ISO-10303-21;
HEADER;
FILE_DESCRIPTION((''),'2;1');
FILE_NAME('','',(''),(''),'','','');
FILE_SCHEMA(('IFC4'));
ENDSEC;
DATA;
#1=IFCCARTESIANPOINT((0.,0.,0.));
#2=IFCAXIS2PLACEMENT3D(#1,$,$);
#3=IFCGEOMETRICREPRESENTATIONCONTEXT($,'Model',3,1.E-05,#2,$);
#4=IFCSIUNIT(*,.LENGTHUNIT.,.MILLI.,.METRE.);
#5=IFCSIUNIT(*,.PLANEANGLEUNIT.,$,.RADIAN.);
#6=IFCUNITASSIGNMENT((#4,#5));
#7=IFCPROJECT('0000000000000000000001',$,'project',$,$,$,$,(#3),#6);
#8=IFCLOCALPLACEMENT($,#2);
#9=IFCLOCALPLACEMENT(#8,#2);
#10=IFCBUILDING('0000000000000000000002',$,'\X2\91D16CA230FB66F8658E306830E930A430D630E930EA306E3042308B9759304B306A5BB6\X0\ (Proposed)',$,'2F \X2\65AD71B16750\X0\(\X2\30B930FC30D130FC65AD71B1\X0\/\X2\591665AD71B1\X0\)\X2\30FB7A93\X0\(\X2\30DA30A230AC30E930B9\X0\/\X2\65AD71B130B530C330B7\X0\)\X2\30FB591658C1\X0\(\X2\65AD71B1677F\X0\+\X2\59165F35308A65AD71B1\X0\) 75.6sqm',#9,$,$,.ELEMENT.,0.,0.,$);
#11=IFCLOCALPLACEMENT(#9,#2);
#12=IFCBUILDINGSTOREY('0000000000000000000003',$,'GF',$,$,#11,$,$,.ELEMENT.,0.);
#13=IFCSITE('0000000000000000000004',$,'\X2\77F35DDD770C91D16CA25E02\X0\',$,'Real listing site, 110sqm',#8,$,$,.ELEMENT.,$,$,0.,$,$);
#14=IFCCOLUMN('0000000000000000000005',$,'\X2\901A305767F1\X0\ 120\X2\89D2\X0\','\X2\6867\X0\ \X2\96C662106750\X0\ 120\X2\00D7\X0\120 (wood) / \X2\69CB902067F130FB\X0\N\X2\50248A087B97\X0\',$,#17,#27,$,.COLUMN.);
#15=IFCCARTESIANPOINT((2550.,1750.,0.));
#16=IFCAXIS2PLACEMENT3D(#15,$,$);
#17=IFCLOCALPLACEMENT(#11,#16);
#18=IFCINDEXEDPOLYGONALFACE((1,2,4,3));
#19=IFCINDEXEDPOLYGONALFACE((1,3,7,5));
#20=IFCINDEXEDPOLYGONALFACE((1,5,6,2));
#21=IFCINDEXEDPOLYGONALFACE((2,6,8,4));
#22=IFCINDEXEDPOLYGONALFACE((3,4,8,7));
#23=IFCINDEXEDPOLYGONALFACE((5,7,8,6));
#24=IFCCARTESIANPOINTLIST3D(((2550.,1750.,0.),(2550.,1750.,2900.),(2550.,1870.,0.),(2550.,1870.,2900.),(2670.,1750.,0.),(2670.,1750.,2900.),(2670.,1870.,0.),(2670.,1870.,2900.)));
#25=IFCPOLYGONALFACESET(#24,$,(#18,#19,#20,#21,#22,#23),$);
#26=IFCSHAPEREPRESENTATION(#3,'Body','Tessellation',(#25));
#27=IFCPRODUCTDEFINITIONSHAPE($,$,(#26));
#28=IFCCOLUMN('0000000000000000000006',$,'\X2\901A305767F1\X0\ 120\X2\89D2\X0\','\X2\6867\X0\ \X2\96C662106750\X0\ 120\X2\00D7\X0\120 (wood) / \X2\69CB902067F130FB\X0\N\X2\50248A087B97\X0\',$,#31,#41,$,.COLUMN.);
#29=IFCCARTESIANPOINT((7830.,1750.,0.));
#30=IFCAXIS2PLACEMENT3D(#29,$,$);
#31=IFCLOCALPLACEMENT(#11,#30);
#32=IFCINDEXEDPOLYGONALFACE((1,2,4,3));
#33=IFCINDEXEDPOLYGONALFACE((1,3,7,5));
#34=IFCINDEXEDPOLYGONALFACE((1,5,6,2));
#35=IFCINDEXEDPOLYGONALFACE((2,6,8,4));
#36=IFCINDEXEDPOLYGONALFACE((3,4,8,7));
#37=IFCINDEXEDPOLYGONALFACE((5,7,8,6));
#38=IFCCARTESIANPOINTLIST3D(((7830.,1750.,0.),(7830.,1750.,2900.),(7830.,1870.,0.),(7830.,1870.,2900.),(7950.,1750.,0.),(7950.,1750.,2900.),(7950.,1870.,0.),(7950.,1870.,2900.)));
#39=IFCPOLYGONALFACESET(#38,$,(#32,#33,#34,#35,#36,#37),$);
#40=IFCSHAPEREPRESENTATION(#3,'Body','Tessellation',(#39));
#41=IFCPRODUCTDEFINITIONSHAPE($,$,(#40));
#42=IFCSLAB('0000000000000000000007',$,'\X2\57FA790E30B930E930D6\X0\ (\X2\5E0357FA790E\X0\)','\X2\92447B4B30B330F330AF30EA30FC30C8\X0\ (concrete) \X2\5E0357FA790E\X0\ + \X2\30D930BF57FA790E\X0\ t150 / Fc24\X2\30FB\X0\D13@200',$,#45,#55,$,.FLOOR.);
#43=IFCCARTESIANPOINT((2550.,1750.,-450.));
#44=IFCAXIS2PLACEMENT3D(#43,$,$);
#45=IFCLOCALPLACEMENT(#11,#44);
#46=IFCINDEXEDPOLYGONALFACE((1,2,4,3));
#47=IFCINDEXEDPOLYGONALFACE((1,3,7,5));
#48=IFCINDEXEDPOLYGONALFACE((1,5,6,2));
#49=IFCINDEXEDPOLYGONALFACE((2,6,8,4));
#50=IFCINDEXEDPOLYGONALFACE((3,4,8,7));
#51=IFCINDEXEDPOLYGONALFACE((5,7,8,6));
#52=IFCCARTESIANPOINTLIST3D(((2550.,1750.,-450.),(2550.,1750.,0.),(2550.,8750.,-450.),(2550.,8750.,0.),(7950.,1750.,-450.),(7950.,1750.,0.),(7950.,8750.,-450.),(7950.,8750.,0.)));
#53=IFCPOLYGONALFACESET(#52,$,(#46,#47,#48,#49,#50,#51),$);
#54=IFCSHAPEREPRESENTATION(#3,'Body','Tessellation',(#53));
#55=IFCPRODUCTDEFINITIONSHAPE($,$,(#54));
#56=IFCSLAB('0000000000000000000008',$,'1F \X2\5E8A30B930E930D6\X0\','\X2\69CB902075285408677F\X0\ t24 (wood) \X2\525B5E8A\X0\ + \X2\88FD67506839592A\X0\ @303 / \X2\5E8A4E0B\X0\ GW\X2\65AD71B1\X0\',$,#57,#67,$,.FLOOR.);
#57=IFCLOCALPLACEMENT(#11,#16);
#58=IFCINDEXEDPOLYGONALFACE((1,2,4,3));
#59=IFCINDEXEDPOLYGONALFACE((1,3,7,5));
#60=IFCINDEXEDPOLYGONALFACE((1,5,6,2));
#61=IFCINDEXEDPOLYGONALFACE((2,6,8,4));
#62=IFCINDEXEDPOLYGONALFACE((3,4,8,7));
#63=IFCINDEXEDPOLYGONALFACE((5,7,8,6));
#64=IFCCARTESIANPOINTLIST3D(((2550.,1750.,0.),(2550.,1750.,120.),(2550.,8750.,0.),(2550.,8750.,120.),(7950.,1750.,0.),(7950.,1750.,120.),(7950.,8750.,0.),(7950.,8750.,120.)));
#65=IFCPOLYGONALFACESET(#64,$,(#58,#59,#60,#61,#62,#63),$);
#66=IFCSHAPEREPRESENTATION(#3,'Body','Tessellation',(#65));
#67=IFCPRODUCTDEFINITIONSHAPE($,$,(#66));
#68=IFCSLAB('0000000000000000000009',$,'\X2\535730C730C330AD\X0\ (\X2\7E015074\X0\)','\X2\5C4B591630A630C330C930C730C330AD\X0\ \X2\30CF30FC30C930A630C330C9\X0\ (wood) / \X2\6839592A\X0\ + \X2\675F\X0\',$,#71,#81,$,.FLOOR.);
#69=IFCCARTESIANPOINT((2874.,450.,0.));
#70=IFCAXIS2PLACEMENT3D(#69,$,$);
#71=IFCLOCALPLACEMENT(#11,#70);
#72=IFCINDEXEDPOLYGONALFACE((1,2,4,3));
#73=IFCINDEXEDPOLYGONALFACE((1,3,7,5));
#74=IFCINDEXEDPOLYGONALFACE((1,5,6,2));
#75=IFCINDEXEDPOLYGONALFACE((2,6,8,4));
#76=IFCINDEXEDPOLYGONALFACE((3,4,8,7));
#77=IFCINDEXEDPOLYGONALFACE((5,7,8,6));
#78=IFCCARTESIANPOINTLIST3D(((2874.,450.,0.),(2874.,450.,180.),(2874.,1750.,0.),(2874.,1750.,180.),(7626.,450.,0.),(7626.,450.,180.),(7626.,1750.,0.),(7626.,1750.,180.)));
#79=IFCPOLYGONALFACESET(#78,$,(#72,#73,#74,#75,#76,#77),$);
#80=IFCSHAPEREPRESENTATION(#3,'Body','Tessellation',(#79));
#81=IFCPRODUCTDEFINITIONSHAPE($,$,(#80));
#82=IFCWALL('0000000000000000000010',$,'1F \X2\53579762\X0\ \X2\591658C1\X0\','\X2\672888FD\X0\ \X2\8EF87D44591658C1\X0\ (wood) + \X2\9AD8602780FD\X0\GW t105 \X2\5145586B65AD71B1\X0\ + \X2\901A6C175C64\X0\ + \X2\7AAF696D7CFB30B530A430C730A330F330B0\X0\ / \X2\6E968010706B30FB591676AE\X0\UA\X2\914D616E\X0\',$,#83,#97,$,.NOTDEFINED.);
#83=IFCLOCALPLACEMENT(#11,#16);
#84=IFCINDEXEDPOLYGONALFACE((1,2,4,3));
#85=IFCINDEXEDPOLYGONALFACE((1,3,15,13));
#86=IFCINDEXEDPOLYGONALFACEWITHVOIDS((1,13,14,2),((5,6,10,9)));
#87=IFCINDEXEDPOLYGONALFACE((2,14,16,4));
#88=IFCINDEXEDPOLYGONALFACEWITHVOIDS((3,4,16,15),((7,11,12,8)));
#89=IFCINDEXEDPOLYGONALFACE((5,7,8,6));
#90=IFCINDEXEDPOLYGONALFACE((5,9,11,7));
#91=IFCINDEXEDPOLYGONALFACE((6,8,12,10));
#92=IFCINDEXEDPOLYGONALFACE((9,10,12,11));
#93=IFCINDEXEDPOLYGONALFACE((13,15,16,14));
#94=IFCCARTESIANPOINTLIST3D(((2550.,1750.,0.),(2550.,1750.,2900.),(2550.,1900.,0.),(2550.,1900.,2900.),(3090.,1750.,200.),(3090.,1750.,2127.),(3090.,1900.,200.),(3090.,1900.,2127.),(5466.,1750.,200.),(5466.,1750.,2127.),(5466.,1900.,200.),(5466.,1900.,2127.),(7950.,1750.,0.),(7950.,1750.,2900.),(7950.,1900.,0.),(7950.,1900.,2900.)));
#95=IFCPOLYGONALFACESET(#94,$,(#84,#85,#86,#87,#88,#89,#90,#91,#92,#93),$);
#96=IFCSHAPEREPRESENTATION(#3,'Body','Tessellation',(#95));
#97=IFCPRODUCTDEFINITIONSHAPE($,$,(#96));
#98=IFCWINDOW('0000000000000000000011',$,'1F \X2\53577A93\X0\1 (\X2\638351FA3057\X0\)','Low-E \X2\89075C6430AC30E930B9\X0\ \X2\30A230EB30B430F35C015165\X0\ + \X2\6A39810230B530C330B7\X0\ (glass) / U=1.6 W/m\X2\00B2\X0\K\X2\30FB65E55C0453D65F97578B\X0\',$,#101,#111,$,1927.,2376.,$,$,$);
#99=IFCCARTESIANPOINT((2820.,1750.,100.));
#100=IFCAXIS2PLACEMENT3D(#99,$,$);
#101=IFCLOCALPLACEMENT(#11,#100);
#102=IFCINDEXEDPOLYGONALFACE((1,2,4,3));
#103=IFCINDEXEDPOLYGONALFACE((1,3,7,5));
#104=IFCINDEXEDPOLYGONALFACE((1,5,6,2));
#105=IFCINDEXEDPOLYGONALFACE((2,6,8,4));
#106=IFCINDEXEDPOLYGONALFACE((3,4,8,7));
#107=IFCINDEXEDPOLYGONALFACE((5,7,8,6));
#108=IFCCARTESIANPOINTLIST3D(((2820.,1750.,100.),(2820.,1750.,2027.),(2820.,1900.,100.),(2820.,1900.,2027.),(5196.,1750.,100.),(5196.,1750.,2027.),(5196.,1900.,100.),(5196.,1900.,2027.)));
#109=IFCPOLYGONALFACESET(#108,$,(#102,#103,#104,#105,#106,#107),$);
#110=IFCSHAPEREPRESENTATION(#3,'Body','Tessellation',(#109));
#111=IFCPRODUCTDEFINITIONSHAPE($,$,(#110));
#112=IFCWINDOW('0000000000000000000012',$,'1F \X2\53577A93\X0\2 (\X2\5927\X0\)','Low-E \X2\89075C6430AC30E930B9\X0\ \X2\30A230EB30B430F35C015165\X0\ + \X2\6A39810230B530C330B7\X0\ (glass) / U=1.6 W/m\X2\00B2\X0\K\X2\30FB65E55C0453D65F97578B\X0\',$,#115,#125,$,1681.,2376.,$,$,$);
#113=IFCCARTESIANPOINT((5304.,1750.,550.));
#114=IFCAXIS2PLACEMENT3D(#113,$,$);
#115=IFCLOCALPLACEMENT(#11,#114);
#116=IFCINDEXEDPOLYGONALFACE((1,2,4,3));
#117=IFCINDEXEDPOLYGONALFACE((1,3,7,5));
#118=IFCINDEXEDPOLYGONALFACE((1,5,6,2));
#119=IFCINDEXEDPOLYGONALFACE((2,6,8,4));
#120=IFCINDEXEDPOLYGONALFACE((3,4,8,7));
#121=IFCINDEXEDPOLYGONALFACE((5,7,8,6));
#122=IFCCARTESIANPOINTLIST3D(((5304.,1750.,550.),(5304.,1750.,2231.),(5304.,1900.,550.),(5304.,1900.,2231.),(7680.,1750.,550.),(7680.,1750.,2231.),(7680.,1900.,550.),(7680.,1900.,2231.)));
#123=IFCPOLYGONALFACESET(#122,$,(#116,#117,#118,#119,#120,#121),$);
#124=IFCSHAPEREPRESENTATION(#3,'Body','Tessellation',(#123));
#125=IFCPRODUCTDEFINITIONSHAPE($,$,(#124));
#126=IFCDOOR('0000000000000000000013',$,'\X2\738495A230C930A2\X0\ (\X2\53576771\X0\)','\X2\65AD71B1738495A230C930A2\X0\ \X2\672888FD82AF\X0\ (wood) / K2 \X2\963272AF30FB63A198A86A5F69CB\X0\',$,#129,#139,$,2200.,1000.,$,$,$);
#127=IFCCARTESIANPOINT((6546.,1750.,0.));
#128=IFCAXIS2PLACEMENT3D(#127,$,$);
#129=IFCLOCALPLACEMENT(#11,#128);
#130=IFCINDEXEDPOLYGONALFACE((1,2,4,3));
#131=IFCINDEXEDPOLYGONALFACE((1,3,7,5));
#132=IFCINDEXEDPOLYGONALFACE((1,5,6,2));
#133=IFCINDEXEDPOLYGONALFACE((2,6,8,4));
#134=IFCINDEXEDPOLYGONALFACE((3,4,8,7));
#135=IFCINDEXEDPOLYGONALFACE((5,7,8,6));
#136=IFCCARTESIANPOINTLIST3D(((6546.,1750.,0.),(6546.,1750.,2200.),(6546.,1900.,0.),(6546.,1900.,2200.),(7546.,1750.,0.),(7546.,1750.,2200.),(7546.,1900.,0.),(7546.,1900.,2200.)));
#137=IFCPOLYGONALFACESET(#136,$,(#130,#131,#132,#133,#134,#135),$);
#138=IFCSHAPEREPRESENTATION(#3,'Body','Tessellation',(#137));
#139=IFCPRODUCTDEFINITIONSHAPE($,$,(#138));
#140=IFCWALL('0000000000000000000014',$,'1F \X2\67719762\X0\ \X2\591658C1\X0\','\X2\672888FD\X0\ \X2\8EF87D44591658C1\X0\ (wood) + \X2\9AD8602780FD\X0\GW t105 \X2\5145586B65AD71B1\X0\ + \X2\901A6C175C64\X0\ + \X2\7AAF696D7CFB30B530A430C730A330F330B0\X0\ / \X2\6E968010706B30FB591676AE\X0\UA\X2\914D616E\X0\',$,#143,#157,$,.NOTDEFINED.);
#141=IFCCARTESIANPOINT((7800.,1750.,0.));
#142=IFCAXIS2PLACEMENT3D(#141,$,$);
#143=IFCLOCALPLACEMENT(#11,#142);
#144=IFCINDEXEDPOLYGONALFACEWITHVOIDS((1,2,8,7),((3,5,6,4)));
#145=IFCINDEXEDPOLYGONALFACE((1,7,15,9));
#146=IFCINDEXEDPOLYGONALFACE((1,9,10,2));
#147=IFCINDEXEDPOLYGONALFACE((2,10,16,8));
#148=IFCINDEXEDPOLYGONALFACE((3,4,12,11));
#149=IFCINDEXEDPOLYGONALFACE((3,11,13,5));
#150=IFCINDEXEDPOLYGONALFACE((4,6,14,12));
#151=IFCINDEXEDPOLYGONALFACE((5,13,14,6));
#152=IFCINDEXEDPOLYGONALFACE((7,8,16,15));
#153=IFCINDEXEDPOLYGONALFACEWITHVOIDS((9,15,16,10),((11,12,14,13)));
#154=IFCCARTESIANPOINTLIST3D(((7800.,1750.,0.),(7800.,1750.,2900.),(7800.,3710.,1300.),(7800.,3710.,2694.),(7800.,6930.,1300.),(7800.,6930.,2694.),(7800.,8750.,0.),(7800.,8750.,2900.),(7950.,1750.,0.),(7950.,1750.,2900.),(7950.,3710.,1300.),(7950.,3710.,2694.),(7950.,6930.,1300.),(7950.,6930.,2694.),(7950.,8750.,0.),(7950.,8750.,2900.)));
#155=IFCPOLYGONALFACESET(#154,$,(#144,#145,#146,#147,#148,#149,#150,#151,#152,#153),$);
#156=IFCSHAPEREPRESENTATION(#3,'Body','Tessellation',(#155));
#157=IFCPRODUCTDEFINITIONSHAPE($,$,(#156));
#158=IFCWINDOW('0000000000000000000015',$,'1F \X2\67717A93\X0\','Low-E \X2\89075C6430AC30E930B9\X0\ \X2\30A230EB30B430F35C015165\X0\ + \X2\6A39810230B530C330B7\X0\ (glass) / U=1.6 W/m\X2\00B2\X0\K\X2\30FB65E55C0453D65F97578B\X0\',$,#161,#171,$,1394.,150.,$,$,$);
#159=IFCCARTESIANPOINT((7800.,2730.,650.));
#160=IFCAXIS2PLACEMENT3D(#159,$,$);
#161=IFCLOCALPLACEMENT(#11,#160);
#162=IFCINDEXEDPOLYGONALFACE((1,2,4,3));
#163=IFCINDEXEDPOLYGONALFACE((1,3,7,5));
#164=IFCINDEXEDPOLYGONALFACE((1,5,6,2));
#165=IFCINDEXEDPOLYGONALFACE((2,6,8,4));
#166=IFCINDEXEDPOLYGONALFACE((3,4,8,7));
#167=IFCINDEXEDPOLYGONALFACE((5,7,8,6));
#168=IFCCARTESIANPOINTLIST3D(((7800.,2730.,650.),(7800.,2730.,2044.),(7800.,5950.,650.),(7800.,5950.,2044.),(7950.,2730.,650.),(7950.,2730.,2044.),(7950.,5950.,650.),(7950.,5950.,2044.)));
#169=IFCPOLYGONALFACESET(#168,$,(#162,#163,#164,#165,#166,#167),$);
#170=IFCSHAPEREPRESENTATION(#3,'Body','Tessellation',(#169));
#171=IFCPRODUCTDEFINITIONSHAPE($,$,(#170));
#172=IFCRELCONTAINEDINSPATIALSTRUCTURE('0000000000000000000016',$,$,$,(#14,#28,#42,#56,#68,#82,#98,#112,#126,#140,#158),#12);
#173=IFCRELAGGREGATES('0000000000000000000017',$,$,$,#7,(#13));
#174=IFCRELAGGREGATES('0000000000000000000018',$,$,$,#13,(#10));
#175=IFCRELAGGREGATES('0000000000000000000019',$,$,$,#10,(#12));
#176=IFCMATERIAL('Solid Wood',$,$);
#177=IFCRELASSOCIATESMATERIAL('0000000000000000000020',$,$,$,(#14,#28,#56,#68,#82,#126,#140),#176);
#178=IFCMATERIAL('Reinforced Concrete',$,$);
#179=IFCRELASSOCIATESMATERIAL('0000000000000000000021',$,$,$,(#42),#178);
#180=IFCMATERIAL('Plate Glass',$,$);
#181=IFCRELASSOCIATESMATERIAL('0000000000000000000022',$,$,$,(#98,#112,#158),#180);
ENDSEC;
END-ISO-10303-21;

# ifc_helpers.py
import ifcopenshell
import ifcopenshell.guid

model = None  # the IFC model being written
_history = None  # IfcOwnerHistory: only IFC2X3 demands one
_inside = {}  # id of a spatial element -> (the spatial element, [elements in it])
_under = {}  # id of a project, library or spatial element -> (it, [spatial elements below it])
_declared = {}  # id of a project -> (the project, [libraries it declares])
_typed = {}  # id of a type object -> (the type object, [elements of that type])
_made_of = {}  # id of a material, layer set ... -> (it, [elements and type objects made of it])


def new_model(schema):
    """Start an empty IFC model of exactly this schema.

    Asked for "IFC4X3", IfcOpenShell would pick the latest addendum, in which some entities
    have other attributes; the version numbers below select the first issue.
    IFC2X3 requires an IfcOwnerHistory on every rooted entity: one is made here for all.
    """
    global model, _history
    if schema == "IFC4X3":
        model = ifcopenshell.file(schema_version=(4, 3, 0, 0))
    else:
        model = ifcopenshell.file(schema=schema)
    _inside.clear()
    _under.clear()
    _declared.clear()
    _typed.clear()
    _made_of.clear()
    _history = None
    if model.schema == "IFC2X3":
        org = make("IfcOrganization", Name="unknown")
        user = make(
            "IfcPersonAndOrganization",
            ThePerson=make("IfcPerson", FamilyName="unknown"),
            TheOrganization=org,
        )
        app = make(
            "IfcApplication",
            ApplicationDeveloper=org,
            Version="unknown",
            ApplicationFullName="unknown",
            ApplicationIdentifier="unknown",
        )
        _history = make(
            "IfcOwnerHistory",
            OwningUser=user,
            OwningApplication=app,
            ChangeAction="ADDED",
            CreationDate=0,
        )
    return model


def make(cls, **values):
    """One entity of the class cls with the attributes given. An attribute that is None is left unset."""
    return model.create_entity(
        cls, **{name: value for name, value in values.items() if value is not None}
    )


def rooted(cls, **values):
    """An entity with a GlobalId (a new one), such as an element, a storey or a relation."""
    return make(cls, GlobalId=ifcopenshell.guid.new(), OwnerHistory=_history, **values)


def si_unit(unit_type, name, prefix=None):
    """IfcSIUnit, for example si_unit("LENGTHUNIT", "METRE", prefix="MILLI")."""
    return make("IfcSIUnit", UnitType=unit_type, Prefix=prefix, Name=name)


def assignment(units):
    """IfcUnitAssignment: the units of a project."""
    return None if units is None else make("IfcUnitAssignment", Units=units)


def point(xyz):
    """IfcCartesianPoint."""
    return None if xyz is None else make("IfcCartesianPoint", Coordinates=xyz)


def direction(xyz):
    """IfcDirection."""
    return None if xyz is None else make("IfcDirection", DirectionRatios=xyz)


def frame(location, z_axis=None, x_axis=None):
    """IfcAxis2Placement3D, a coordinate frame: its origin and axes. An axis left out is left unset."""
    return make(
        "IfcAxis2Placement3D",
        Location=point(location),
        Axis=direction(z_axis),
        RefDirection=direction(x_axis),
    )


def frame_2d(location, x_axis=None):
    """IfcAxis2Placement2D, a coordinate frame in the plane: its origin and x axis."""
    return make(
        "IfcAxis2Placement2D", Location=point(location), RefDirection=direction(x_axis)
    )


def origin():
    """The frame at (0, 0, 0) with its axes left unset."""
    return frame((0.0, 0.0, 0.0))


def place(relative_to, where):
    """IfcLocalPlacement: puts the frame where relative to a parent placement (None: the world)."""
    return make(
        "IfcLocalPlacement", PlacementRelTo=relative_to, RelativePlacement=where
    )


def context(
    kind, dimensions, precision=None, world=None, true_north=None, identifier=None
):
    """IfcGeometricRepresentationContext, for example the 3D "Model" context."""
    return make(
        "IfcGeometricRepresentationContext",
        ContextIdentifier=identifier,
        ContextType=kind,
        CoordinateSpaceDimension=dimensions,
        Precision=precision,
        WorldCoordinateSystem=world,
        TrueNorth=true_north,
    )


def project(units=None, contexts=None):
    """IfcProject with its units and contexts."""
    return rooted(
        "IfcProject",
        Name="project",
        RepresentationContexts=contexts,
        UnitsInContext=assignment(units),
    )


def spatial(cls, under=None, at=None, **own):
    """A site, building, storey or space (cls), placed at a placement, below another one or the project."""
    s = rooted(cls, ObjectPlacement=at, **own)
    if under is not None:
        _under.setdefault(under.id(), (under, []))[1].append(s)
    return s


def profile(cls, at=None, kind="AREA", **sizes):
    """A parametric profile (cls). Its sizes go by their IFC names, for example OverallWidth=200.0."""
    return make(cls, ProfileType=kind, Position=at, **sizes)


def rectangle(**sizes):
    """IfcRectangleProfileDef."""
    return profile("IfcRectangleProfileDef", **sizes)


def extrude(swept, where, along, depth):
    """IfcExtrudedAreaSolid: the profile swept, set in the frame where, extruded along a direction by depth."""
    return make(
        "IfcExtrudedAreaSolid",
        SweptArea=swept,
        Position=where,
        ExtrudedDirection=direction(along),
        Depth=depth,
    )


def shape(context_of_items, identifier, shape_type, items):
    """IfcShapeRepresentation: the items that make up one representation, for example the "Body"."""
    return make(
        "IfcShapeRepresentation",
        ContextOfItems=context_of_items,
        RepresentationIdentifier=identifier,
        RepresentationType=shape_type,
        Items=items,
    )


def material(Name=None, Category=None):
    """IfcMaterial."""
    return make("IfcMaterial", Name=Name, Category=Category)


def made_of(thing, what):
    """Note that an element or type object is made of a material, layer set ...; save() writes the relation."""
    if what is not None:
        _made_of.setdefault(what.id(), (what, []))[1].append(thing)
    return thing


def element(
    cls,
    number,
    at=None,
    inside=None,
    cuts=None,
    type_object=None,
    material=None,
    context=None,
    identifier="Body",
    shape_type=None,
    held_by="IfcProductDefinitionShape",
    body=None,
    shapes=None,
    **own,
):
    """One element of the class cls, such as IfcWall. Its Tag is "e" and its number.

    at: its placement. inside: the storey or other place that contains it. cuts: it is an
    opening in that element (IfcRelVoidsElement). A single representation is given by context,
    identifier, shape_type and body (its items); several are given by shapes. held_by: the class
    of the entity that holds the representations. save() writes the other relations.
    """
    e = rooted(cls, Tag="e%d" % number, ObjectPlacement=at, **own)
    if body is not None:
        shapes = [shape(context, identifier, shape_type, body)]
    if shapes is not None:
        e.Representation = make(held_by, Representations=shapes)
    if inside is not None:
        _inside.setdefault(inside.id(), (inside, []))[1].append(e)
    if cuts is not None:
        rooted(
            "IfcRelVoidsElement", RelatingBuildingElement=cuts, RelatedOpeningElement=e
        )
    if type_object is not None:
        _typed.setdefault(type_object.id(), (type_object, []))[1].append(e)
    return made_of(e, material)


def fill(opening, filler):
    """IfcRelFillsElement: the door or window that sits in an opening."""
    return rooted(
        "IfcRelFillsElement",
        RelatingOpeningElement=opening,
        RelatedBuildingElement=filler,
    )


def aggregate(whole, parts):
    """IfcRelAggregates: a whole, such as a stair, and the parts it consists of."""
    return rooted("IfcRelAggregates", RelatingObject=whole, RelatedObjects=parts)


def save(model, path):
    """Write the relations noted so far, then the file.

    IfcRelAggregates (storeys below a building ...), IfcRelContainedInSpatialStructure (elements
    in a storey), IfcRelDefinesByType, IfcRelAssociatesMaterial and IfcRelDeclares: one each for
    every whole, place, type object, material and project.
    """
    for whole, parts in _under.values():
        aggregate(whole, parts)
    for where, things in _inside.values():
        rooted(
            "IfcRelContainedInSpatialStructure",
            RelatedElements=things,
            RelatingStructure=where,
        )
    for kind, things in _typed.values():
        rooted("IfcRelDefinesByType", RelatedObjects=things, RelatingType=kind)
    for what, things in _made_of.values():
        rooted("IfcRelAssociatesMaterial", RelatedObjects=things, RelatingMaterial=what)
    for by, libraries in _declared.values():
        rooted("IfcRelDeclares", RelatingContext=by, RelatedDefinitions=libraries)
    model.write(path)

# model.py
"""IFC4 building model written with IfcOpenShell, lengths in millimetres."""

from ifc_helpers import new_model, si_unit, frame, frame_2d, origin, place, context, project, spatial, rectangle, extrude, material, element, fill, save


model = new_model("IFC4")

# Units and contexts
model_context = context("Model", 3, precision=1e-05, world=origin())
ifc_project = project(units=[si_unit("LENGTHUNIT", "METRE", prefix="MILLI"), si_unit("PLANEANGLEUNIT", "RADIAN")], contexts=[model_context])

# Site, building, storey
site_placement = place(None, origin())
site = spatial("IfcSite", under=ifc_project, at=site_placement, Name="石川県金沢市", ObjectType="Real listing site, 110sqm", CompositionType="ELEMENT", RefElevation=0.0)
building_placement = place(site_placement, origin())
building = spatial("IfcBuilding", under=site, at=building_placement, Name="金沢・書斎とライブラリのある静かな家 (Proposed)", ObjectType="2F 断熱材(スーパー断熱/外断熱)・窓(ペアガラス/断熱サッシ)・外壁(断熱板+外張り断熱) 75.6sqm", CompositionType="ELEMENT", ElevationOfRefHeight=0.0, ElevationOfTerrain=0.0)
storey_placement = place(building_placement, origin())
storey = spatial("IfcBuildingStorey", under=building, at=storey_placement, Name="GF", CompositionType="ELEMENT", Elevation=0.0)

# Columns
ifc_material_1 = material(Name="Solid Wood")
column_1_placement = place(storey_placement, frame((2550.0, 1750.0, 0.0)))
element("IfcColumn", 1, at=column_1_placement, inside=storey, material=ifc_material_1, Name="通し柱 120角", Description="桧 集成材 120×120 (wood) / 構造柱・N値計算", PredefinedType="COLUMN", context=model_context, shape_type="SweptSolid", body=[
    extrude(rectangle(XDim=120.0, YDim=120.0, at=frame_2d((60.0, 60.0))), frame((2550.0, 1750.0, 0.0)), (0.0, 0.0, 1.0), 2900.0),
])
column_2_placement = place(storey_placement, frame((7830.0, 1750.0, 0.0)))
element("IfcColumn", 2, at=column_2_placement, inside=storey, material=ifc_material_1, Name="通し柱 120角", Description="桧 集成材 120×120 (wood) / 構造柱・N値計算", PredefinedType="COLUMN", context=model_context, shape_type="SweptSolid", body=[
    extrude(rectangle(XDim=120.0, YDim=120.0, at=frame_2d((60.0, 60.0))), frame((7830.0, 1750.0, 0.0)), (0.0, 0.0, 1.0), 2900.0),
])

# Slabs
ifc_material_2 = material(Name="Reinforced Concrete")
slab_1_placement = place(storey_placement, frame((2550.0, 1750.0, -450.0)))
element("IfcSlab", 3, at=slab_1_placement, inside=storey, material=ifc_material_2, Name="基礎スラブ (布基礎)", Description="鉄筋コンクリート (concrete) 布基礎 + ベタ基礎 t150 / Fc24・D13@200", PredefinedType="FLOOR", context=model_context, shape_type="SweptSolid", body=[
    extrude(rectangle(XDim=5400.0, YDim=7000.0, at=frame_2d((2700.0, 3500.0))), frame((2550.0, 1750.0, -450.0)), (0.0, 0.0, 1.0), 450.0),
])
slab_2_placement = place(storey_placement, frame((2550.0, 1750.0, 0.0)))
element("IfcSlab", 4, at=slab_2_placement, inside=storey, material=ifc_material_1, Name="1F 床スラブ", Description="構造用合板 t24 (wood) 剛床 + 製材根太 @303 / 床下 GW断熱", PredefinedType="FLOOR", context=model_context, shape_type="SweptSolid", body=[
    extrude(rectangle(XDim=5400.0, YDim=7000.0, at=frame_2d((2700.0, 3500.0))), frame((2550.0, 1750.0, 0.0)), (0.0, 0.0, 1.0), 120.0),
])
slab_3_placement = place(storey_placement, frame((2874.0, 450.0, 0.0)))
element("IfcSlab", 5, at=slab_3_placement, inside=storey, material=ifc_material_1, Name="南デッキ (縁側)", Description="屋外ウッドデッキ ハードウッド (wood) / 根太 + 束", PredefinedType="FLOOR", context=model_context, shape_type="SweptSolid", body=[
    extrude(rectangle(XDim=4752.0, YDim=1300.0, at=frame_2d((2376.0, 650.0))), frame((2874.0, 450.0, 0.0)), (0.0, 0.0, 1.0), 180.0),
])

# Wall, openings, windows, door
wall_1_placement = place(storey_placement, frame((2550.0, 1750.0, 0.0)))
wall_1 = element("IfcWall", 6, at=wall_1_placement, inside=storey, material=ifc_material_1, Name="1F 南面 外壁", Description="木製 軸組外壁 (wood) + 高性能GW t105 充填断熱 + 通気層 + 窯業系サイディング / 準耐火・外皮UA配慮", PredefinedType="NOTDEFINED", context=model_context, shape_type="SweptSolid", body=[
    extrude(rectangle(XDim=5400.0, YDim=150.0, at=frame_2d((2700.0, 75.0))), frame((2550.0, 1750.0, 0.0)), (0.0, 0.0, 1.0), 2900.0),
])
opening_1_placement = place(storey_placement, frame((2820.0, 1750.0, 100.0)))
opening_1 = element("IfcOpeningElement", 7, at=opening_1_placement, cuts=wall_1, PredefinedType="NOTDEFINED", context=model_context, shape_type="SweptSolid", body=[
    extrude(rectangle(XDim=2376.0, YDim=150.0, at=frame_2d((1188.0, 75.0))), frame((2820.0, 1750.0, 100.0)), (0.0, 0.0, 1.0), 1927.0),
])
opening_2_placement = place(storey_placement, frame((5304.0, 1750.0, 550.0)))
opening_2 = element("IfcOpeningElement", 8, at=opening_2_placement, cuts=wall_1, PredefinedType="NOTDEFINED", context=model_context, shape_type="SweptSolid", body=[
    extrude(rectangle(XDim=2376.0, YDim=150.0, at=frame_2d((1188.0, 75.0))), frame((5304.0, 1750.0, 550.0)), (0.0, 0.0, 1.0), 1681.0),
])
opening_3_placement = place(storey_placement, frame((6546.0, 1750.0, 0.0)))
opening_3 = element("IfcOpeningElement", 9, at=opening_3_placement, cuts=wall_1, PredefinedType="NOTDEFINED", context=model_context, shape_type="SweptSolid", body=[
    extrude(rectangle(XDim=1000.0, YDim=150.0, at=frame_2d((500.0, 75.0))), frame((6546.0, 1750.0, 0.0)), (0.0, 0.0, 1.0), 2200.0),
])
ifc_material_3 = material(Name="Plate Glass")
window_1_placement = place(storey_placement, frame((2820.0, 1750.0, 100.0)))
window_1 = element("IfcWindow", 10, at=window_1_placement, inside=storey, material=ifc_material_3, Name="1F 南窓1 (掃出し)", Description="Low-E 複層ガラス アルゴン封入 + 樹脂サッシ (glass) / U=1.6 W/m²K・日射取得型", OverallHeight=1927.0, OverallWidth=2376.0, context=model_context, shape_type="SweptSolid", body=[
    extrude(rectangle(XDim=2376.0, YDim=150.0, at=frame_2d((1188.0, 75.0))), frame((2820.0, 1750.0, 100.0)), (0.0, 0.0, 1.0), 1927.0),
])
fill(opening_1, window_1)
window_2_placement = place(storey_placement, frame((5304.0, 1750.0, 550.0)))
window_2 = element("IfcWindow", 11, at=window_2_placement, inside=storey, material=ifc_material_3, Name="1F 南窓2 (大)", Description="Low-E 複層ガラス アルゴン封入 + 樹脂サッシ (glass) / U=1.6 W/m²K・日射取得型", OverallHeight=1681.0, OverallWidth=2376.0, context=model_context, shape_type="SweptSolid", body=[
    extrude(rectangle(XDim=2376.0, YDim=150.0, at=frame_2d((1188.0, 75.0))), frame((5304.0, 1750.0, 550.0)), (0.0, 0.0, 1.0), 1681.0),
])
fill(opening_2, window_2)
door_placement = place(storey_placement, frame((6546.0, 1750.0, 0.0)))
door = element("IfcDoor", 12, at=door_placement, inside=storey, material=ifc_material_1, Name="玄関ドア (南東)", Description="断熱玄関ドア 木製芯 (wood) / K2 防犯・採風機構", OverallHeight=2200.0, OverallWidth=1000.0, context=model_context, shape_type="SweptSolid", body=[
    extrude(rectangle(XDim=1000.0, YDim=150.0, at=frame_2d((500.0, 75.0))), frame((6546.0, 1750.0, 0.0)), (0.0, 0.0, 1.0), 2200.0),
])
fill(opening_3, door)

# Wall, opening, window
wall_2_placement = place(storey_placement, frame((7800.0, 1750.0, 0.0)))
wall_2 = element("IfcWall", 13, at=wall_2_placement, inside=storey, material=ifc_material_1, Name="1F 東面 外壁", Description="木製 軸組外壁 (wood) + 高性能GW t105 充填断熱 + 通気層 + 窯業系サイディング / 準耐火・外皮UA配慮", PredefinedType="NOTDEFINED", context=model_context, shape_type="SweptSolid", body=[
    extrude(rectangle(XDim=150.0, YDim=7000.0, at=frame_2d((75.0, 3500.0))), frame((7800.0, 1750.0, 0.0)), (0.0, 0.0, 1.0), 2900.0),
])
opening_4_placement = place(storey_placement, frame((7800.0, 2730.0, 650.0)))
opening_4 = element("IfcOpeningElement", 14, at=opening_4_placement, cuts=wall_2, PredefinedType="NOTDEFINED", context=model_context, shape_type="SweptSolid", body=[
    extrude(rectangle(XDim=150.0, YDim=3220.0, at=frame_2d((75.0, 1610.0))), frame((7800.0, 2730.0, 650.0)), (0.0, 0.0, 1.0), 1394.0),
])
window_3_placement = place(storey_placement, frame((7800.0, 2730.0, 650.0)))
window_3 = element("IfcWindow", 15, at=window_3_placement, inside=storey, material=ifc_material_3, Name="1F 東窓", Description="Low-E 複層ガラス アルゴン封入 + 樹脂サッシ (glass) / U=1.6 W/m²K・日射取得型", OverallHeight=1394.0, OverallWidth=150.0, context=model_context, shape_type="SweptSolid", body=[
    extrude(rectangle(XDim=150.0, YDim=3220.0, at=frame_2d((75.0, 1610.0))), frame((7800.0, 2730.0, 650.0)), (0.0, 0.0, 1.0), 1394.0),
])
fill(opening_4, window_3)

save(model, "model.ifc")
